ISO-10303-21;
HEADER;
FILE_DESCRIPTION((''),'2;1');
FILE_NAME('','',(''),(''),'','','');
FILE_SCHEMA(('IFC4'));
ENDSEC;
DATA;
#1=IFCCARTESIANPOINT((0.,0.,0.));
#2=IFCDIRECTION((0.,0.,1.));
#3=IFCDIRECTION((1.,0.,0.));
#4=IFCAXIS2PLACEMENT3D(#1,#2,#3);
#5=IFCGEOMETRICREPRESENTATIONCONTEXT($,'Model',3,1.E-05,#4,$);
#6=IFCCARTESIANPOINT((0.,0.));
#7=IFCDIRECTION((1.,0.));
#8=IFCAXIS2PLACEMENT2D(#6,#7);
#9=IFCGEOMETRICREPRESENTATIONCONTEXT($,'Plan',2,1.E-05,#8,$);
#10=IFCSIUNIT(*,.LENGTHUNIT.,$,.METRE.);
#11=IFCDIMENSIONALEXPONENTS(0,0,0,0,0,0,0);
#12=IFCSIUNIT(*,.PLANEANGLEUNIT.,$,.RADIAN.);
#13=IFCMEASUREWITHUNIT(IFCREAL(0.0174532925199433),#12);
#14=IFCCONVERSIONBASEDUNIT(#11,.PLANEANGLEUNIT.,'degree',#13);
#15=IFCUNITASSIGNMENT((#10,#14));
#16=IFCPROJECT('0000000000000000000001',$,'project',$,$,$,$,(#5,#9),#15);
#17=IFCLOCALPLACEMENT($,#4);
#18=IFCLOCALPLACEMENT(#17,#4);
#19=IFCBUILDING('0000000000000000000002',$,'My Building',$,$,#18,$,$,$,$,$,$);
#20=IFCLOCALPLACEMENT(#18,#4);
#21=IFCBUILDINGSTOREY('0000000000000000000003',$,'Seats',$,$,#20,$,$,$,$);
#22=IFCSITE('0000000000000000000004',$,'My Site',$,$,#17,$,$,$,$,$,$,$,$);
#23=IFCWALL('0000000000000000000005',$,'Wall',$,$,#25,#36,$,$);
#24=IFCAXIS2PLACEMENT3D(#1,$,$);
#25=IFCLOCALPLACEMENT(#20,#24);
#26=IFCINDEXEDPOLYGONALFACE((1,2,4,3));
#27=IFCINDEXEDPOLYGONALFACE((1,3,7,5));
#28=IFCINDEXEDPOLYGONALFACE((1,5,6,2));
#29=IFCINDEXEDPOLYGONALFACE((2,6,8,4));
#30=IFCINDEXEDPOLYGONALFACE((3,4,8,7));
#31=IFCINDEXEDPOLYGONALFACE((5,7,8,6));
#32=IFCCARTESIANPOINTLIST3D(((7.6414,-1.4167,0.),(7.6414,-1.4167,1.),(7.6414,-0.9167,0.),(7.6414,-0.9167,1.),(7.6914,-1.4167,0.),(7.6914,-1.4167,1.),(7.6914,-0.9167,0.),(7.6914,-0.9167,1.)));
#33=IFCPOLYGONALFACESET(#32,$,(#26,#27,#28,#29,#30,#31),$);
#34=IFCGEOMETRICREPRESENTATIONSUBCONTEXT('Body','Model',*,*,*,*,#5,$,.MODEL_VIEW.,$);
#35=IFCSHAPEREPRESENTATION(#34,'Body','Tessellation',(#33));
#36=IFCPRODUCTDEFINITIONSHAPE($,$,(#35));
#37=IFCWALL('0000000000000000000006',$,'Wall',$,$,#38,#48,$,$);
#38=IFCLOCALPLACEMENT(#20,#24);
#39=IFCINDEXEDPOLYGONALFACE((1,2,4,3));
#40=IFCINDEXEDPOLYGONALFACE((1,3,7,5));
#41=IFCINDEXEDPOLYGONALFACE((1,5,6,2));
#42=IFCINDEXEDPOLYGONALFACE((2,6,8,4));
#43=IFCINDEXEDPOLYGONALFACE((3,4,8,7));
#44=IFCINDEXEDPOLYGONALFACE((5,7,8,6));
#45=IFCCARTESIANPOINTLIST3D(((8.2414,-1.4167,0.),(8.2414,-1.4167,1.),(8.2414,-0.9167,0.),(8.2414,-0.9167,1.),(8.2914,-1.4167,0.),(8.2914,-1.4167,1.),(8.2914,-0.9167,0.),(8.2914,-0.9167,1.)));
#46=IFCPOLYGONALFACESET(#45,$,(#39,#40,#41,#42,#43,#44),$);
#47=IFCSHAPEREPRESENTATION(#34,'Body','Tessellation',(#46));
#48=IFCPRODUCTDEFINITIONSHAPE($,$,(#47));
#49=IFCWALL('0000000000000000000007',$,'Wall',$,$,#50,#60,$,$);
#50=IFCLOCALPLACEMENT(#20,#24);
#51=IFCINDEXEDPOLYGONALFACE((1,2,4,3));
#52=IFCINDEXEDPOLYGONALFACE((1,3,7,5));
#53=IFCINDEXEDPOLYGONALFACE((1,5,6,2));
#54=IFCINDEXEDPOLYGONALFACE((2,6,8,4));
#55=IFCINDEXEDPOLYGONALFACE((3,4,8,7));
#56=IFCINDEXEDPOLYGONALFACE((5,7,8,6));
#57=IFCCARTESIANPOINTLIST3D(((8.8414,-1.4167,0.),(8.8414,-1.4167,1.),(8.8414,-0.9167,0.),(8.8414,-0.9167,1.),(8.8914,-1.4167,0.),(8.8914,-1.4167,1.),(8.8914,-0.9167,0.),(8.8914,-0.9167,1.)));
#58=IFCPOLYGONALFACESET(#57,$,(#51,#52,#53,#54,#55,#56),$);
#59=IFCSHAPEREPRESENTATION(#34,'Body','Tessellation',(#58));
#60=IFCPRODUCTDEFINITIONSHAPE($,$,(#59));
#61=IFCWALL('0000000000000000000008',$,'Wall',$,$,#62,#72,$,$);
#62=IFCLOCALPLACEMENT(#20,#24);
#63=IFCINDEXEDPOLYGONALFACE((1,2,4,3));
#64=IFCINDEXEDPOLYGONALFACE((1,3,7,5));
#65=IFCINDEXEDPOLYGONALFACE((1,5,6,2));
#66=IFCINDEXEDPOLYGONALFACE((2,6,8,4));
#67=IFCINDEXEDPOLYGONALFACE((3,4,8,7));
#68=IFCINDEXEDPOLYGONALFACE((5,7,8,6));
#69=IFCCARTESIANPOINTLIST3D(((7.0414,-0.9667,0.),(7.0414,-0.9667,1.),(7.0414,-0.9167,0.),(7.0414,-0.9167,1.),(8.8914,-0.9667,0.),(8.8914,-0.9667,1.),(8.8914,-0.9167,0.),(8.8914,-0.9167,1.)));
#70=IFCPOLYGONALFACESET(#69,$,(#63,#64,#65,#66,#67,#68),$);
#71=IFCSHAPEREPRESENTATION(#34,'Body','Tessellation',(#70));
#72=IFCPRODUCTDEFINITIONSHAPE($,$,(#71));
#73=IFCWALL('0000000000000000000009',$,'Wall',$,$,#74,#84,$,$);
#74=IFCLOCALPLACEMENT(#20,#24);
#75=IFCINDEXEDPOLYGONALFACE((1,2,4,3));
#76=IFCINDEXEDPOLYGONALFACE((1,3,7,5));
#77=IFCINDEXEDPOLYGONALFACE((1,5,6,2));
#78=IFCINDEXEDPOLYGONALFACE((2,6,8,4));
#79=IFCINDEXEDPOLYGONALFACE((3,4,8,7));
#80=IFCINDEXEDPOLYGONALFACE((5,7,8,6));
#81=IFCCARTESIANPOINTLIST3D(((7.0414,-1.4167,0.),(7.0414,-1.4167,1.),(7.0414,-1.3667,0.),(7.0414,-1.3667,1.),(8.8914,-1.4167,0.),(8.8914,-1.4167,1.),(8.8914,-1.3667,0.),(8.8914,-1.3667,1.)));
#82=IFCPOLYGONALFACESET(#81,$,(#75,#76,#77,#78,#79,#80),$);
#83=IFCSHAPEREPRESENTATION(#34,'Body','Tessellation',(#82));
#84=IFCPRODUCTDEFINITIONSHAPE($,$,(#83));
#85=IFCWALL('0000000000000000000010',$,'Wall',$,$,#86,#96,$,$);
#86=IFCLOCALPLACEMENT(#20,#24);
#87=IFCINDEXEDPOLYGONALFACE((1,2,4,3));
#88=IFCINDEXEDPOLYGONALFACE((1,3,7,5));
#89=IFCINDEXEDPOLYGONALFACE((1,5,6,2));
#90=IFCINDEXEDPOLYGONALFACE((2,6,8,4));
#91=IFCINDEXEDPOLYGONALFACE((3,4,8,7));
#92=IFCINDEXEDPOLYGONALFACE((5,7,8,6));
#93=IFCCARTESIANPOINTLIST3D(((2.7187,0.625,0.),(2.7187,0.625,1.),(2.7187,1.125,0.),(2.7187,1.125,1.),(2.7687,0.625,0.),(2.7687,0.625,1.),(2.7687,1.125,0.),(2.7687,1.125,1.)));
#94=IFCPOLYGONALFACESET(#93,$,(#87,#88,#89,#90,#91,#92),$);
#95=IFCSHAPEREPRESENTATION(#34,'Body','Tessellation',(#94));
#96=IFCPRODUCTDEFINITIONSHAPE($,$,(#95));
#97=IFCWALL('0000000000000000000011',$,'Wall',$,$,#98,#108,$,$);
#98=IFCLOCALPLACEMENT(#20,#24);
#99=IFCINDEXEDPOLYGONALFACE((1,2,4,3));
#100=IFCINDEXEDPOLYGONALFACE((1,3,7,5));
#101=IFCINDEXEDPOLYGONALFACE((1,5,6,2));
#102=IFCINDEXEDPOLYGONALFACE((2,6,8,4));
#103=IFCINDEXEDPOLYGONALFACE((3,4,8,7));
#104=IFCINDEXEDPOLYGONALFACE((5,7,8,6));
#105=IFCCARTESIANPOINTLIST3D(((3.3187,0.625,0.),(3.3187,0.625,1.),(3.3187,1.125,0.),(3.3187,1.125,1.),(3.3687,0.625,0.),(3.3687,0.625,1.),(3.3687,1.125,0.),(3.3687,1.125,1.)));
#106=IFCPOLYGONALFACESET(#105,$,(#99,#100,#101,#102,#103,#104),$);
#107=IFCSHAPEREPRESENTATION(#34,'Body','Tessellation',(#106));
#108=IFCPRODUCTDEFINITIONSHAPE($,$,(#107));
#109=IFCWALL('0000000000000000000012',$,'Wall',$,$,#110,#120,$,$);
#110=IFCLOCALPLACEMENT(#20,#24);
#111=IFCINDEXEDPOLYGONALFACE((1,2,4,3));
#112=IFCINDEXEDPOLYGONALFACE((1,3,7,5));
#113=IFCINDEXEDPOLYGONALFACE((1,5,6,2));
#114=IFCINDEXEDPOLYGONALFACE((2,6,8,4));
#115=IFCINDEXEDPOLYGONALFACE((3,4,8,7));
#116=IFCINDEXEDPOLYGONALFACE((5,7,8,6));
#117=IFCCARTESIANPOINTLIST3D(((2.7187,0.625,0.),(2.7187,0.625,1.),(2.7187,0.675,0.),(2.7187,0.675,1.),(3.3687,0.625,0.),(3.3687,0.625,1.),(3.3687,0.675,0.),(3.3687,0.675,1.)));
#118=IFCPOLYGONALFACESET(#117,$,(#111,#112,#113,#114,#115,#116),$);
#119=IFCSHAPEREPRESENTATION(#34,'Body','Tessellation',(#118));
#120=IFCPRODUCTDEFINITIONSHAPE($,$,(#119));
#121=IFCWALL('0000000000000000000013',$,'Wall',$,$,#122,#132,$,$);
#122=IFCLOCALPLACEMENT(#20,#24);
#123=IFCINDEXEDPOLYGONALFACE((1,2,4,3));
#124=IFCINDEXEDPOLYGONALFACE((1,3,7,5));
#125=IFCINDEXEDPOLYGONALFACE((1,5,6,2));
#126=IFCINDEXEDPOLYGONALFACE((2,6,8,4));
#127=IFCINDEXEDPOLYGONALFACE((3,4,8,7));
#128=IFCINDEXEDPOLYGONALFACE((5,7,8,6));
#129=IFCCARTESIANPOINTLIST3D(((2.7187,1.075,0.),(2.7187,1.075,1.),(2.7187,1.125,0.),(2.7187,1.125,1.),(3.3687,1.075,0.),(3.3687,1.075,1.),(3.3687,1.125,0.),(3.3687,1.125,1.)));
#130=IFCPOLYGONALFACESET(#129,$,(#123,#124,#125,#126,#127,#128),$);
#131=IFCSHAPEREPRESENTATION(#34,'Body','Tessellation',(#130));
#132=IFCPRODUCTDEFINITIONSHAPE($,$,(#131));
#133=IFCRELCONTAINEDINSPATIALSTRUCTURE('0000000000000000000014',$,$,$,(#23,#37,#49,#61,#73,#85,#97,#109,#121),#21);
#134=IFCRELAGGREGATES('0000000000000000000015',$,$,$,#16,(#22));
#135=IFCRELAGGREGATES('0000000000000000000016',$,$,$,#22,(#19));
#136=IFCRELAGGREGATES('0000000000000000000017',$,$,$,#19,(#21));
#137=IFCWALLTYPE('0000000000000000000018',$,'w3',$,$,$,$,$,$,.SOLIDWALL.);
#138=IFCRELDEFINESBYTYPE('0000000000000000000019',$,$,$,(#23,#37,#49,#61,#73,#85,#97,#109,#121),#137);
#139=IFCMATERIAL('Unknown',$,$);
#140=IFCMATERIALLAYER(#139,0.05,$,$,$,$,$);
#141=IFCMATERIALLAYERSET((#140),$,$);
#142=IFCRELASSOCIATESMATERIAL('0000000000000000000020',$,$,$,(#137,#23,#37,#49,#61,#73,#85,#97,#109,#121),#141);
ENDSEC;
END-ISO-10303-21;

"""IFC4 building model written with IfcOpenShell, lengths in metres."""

from ifc_helpers import new_model, entity, si_unit, converted_unit, frame, origin_with_axes, origin_2d_with_axis, place, context, subcontext, project, spatial, line, indexed_curve, outline, extrude, material, layer, layer_set, layer_usage, type_object, element, save


model = new_model("IFC4")

# Units and contexts
model_context = context("Model", 3, precision=1e-05, world=origin_with_axes())
plan_context = context("Plan", 2, precision=1e-05, world=origin_2d_with_axis())
body_context = subcontext(model_context, "Body", "Model", "MODEL_VIEW")
ifc_project = project(units=[si_unit("LENGTHUNIT", "METRE"), converted_unit("PLANEANGLEUNIT", "degree", entity("IfcReal", 0.0174532925199433), si_unit("PLANEANGLEUNIT", "RADIAN"), dimensions=[0, 0, 0, 0, 0, 0, 0])], contexts=[model_context, plan_context])

# Site, building, storey
site_placement = place(None, origin_with_axes())
site = spatial("IfcSite", under=ifc_project, at=site_placement, Name="My Site")
building_placement = place(site_placement, origin_with_axes())
building = spatial("IfcBuilding", under=site, at=building_placement, Name="My Building")
storey_placement = place(building_placement, origin_with_axes())
storey = spatial("IfcBuildingStorey", under=building, at=storey_placement, Name="Seats")

# Shared definitions
ifc_material = material(Name="Unknown")

# Walls
ifc_layer_1 = layer(ifc_material, 0.05)
ifc_layer_set_1 = layer_set([ifc_layer_1])
wall_type = type_object("IfcWallType", Name="w3", PredefinedType="SOLIDWALL", material=ifc_layer_set_1)
ifc_layer_usage_1 = layer_usage(ifc_layer_set_1, "AXIS2", "POSITIVE", 0.0)
wall_1_placement = place(storey_placement, frame((7.6414, -0.9167, 0.0), z_axis=(0.0, 0.0, 1.0), x_axis=(0.0, -1.0, 0.0)))
element("IfcWall", 1, at=wall_1_placement, inside=storey, type_object=wall_type, material=ifc_layer_usage_1, Name="Wall", context=body_context, shape_type="SweptSolid", body=[
    extrude(outline(indexed_curve([(0.0, 0.0), (0.0, 0.05), (0.5, 0.05), (0.5, 0.0)], segments=[line(1, 2, 3, 4, 1)])), origin_with_axes(), (0.0, 0.0, 1.0), 1.0),
])
ifc_layer_usage_2 = layer_usage(ifc_layer_set_1, "AXIS2", "POSITIVE", 0.0)
wall_2_placement = place(storey_placement, frame((8.2414, -0.9167, 0.0), z_axis=(0.0, 0.0, 1.0), x_axis=(0.0, -1.0, 0.0)))
element("IfcWall", 2, at=wall_2_placement, inside=storey, type_object=wall_type, material=ifc_layer_usage_2, Name="Wall", context=body_context, shape_type="SweptSolid", body=[
    extrude(outline(indexed_curve([(0.0, 0.0), (0.0, 0.05), (0.5, 0.05), (0.5, 0.0)], segments=[line(1, 2, 3, 4, 1)])), origin_with_axes(), (0.0, 0.0, 1.0), 1.0),
])
ifc_layer_usage_3 = layer_usage(ifc_layer_set_1, "AXIS2", "POSITIVE", 0.0)
wall_3_placement = place(storey_placement, frame((8.8414, -0.9167, 0.0), z_axis=(0.0, 0.0, 1.0), x_axis=(0.0, -1.0, 0.0)))
element("IfcWall", 3, at=wall_3_placement, inside=storey, type_object=wall_type, material=ifc_layer_usage_3, Name="Wall", context=body_context, shape_type="SweptSolid", body=[
    extrude(outline(indexed_curve([(0.0, 0.0), (0.0, 0.05), (0.5, 0.05), (0.5, 0.0)], segments=[line(1, 2, 3, 4, 1)])), origin_with_axes(), (0.0, 0.0, 1.0), 1.0),
])
ifc_layer_usage_4 = layer_usage(ifc_layer_set_1, "AXIS2", "POSITIVE", 0.0)
wall_4_placement = place(storey_placement, frame((7.0414, -0.9667, 0.0), z_axis=(0.0, 0.0, 1.0), x_axis=(1.0, 0.0, 0.0)))
element("IfcWall", 4, at=wall_4_placement, inside=storey, type_object=wall_type, material=ifc_layer_usage_4, Name="Wall", context=body_context, shape_type="SweptSolid", body=[
    extrude(outline(indexed_curve([(0.0, 0.0), (0.0, 0.05), (1.85, 0.05), (1.85, 0.0)], segments=[line(1, 2, 3, 4, 1)])), origin_with_axes(), (0.0, 0.0, 1.0), 1.0),
])
ifc_layer_usage_5 = layer_usage(ifc_layer_set_1, "AXIS2", "POSITIVE", 0.0)
wall_5_placement = place(storey_placement, frame((7.0414, -1.4167, 0.0), z_axis=(0.0, 0.0, 1.0), x_axis=(1.0, 0.0, 0.0)))
element("IfcWall", 5, at=wall_5_placement, inside=storey, type_object=wall_type, material=ifc_layer_usage_5, Name="Wall", context=body_context, shape_type="SweptSolid", body=[
    extrude(outline(indexed_curve([(0.0, 0.0), (0.0, 0.05), (1.85, 0.05), (1.85, 0.0)], segments=[line(1, 2, 3, 4, 1)])), origin_with_axes(), (0.0, 0.0, 1.0), 1.0),
])
ifc_layer_usage_6 = layer_usage(ifc_layer_set_1, "AXIS2", "POSITIVE", 0.0)
wall_6_placement = place(storey_placement, frame((2.7187, 1.125, 0.0), z_axis=(0.0, 0.0, 1.0), x_axis=(0.0, -1.0, 0.0)))
element("IfcWall", 6, at=wall_6_placement, inside=storey, type_object=wall_type, material=ifc_layer_usage_6, Name="Wall", context=body_context, shape_type="SweptSolid", body=[
    extrude(outline(indexed_curve([(0.0, 0.0), (0.0, 0.05), (0.5, 0.05), (0.5, 0.0)], segments=[line(1, 2, 3, 4, 1)])), origin_with_axes(), (0.0, 0.0, 1.0), 1.0),
])
ifc_layer_usage_7 = layer_usage(ifc_layer_set_1, "AXIS2", "POSITIVE", 0.0)
wall_7_placement = place(storey_placement, frame((3.3187, 1.125, 0.0), z_axis=(0.0, 0.0, 1.0), x_axis=(0.0, -1.0, 0.0)))
element("IfcWall", 7, at=wall_7_placement, inside=storey, type_object=wall_type, material=ifc_layer_usage_7, Name="Wall", context=body_context, shape_type="SweptSolid", body=[
    extrude(outline(indexed_curve([(0.0, 0.0), (0.0, 0.05), (0.5, 0.05), (0.5, 0.0)], segments=[line(1, 2, 3, 4, 1)])), origin_with_axes(), (0.0, 0.0, 1.0), 1.0),
])
ifc_layer_usage_8 = layer_usage(ifc_layer_set_1, "AXIS2", "POSITIVE", 0.0)
wall_8_placement = place(storey_placement, frame((3.3687, 0.675, 0.0), z_axis=(0.0, 0.0, 1.0), x_axis=(-1.0, 0.0, 0.0)))
element("IfcWall", 8, at=wall_8_placement, inside=storey, type_object=wall_type, material=ifc_layer_usage_8, Name="Wall", context=body_context, shape_type="SweptSolid", body=[
    extrude(outline(indexed_curve([(0.0, 0.0), (0.0, 0.05), (0.65, 0.05), (0.65, 0.0)], segments=[line(1, 2, 3, 4, 1)])), origin_with_axes(), (0.0, 0.0, 1.0), 1.0),
])
ifc_layer_usage_9 = layer_usage(ifc_layer_set_1, "AXIS2", "POSITIVE", 0.0)
wall_9_placement = place(storey_placement, frame((3.3687, 1.125, 0.0), z_axis=(0.0, 0.0, 1.0), x_axis=(-1.0, 0.0, 0.0)))
element("IfcWall", 9, at=wall_9_placement, inside=storey, type_object=wall_type, material=ifc_layer_usage_9, Name="Wall", context=body_context, shape_type="SweptSolid", body=[
    extrude(outline(indexed_curve([(0.0, 0.0), (0.0, 0.05), (0.65, 0.05), (0.65, 0.0)], segments=[line(1, 2, 3, 4, 1)])), origin_with_axes(), (0.0, 0.0, 1.0), 1.0),
])

save(model, "model.ifc")
